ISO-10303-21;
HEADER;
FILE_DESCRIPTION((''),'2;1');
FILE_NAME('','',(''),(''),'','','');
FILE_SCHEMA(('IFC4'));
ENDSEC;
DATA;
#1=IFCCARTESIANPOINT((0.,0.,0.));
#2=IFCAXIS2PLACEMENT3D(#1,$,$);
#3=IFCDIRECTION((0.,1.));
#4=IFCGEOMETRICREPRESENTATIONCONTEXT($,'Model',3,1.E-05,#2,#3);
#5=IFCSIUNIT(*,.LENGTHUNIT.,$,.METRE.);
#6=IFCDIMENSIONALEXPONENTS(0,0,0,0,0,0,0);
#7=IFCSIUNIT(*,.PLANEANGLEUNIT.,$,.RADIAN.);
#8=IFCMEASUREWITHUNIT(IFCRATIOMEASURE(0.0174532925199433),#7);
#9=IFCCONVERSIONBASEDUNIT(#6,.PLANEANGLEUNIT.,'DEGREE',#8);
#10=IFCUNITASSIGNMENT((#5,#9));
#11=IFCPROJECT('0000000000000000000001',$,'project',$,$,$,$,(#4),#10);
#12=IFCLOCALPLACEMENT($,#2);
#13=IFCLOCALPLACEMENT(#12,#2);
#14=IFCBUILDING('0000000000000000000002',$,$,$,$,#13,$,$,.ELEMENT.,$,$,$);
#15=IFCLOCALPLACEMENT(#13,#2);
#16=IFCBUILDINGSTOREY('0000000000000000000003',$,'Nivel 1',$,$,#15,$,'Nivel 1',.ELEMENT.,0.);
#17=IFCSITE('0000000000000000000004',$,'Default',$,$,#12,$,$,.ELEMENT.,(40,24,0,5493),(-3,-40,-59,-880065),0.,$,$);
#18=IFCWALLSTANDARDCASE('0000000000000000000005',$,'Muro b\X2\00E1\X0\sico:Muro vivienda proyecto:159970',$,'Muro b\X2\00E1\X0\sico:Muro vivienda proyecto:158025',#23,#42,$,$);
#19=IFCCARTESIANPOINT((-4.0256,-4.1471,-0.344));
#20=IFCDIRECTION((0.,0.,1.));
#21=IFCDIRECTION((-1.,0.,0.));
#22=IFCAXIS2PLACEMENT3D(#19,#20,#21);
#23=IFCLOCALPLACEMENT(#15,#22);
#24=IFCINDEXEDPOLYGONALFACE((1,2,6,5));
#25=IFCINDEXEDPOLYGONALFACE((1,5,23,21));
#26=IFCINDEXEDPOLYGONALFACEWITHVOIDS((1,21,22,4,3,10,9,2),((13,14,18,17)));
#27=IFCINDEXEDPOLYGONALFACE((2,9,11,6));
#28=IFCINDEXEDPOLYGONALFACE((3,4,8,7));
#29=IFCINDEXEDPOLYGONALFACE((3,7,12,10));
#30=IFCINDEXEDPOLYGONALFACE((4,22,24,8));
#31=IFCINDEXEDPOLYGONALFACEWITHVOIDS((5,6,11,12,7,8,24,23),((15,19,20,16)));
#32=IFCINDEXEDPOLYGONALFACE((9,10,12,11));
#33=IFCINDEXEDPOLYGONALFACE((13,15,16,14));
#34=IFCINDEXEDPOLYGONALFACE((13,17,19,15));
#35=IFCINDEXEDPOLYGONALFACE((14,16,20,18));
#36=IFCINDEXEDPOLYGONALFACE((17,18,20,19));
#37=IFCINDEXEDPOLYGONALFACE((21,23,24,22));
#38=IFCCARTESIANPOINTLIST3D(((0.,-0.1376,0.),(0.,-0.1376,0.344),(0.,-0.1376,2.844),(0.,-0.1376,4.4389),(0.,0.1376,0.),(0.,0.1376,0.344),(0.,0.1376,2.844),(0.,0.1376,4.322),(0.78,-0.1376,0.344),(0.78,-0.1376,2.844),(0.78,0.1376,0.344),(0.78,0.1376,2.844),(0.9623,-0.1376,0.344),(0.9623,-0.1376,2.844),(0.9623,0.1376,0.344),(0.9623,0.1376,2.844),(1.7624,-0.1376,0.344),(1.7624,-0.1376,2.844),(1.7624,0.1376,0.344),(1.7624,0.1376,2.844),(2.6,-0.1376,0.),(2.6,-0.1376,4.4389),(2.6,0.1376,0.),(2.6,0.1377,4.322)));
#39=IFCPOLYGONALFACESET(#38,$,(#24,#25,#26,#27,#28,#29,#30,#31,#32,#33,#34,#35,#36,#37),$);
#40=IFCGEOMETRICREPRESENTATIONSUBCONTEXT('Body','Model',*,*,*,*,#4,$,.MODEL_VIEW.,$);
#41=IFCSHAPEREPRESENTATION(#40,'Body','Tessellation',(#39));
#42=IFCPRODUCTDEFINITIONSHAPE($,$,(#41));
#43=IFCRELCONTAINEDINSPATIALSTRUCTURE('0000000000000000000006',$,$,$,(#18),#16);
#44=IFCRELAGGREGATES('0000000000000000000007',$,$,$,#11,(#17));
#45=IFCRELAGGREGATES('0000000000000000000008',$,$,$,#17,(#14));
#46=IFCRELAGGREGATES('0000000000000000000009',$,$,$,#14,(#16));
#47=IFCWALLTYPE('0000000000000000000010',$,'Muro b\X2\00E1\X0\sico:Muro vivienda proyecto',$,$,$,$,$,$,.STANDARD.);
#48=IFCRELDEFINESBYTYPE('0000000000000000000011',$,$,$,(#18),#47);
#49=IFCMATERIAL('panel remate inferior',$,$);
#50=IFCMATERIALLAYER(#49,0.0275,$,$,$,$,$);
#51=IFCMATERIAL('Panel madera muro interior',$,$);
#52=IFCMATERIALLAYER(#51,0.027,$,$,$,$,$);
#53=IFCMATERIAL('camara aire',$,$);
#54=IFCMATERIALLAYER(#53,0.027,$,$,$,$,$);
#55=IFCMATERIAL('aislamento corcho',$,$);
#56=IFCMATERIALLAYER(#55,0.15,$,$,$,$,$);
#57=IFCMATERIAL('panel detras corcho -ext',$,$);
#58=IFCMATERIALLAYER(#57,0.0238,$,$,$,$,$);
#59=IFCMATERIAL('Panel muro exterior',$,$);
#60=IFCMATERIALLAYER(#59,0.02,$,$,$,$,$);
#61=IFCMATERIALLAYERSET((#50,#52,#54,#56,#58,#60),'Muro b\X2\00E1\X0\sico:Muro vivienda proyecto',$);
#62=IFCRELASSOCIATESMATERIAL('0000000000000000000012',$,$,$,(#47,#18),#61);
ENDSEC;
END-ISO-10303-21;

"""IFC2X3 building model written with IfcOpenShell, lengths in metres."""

from ifc_helpers import new_model, entity, si_unit, converted_unit, direction, frame, frame_2d, origin, origin_2d_with_axis, place, context, subcontext, project, spatial, polyline, rectangle, extrude, clip, bounded_halfspace, material, layer, layer_set, layer_usage, type_object, element, save


model = new_model("IFC2X3")

# Units and contexts
model_context = context("Model", 3, precision=1e-05, world=origin(), true_north=direction((0.0, 1.0)))
body_context = subcontext(model_context, "Body", "Model", "MODEL_VIEW")
ifc_project = project(units=[si_unit("LENGTHUNIT", "METRE"), converted_unit("PLANEANGLEUNIT", "DEGREE", entity("IfcRatioMeasure", 0.0174532925199433), si_unit("PLANEANGLEUNIT", "RADIAN"), dimensions=[0, 0, 0, 0, 0, 0, 0])], contexts=[model_context])

# Site, building, storey
site_placement = place(None, origin())
site = spatial("IfcSite", under=ifc_project, at=site_placement, Name="Default", CompositionType="ELEMENT", RefLatitude=(40, 24, 0, 5493), RefLongitude=(-3, -40, -59, -880065), RefElevation=0.0)
building_placement = place(site_placement, origin())
building = spatial("IfcBuilding", under=site, at=building_placement, CompositionType="ELEMENT")
storey_placement = place(building_placement, origin())
storey = spatial("IfcBuildingStorey", under=building, at=storey_placement, Name="Nivel 1", LongName="Nivel 1", CompositionType="ELEMENT", Elevation=0.0)

# Shared definitions
ifc_material_1 = material(Name="aislamento corcho")
ifc_material_2 = material(Name="camara aire")
ifc_material_3 = material(Name="panel remate inferior")

# Shared definitions
ifc_layer_1 = layer(ifc_material_3, 0.0275)
ifc_material_4 = material(Name="Panel madera muro interior")
ifc_layer_2 = layer(ifc_material_4, 0.027)
ifc_layer_3 = layer(ifc_material_2, 0.027)
ifc_layer_4 = layer(ifc_material_1, 0.15)
ifc_material_5 = material(Name="panel detras corcho -ext")
ifc_layer_5 = layer(ifc_material_5, 0.0238)
ifc_material_6 = material(Name="Panel muro exterior")
ifc_layer_6 = layer(ifc_material_6, 0.02)
ifc_layer_set_1 = layer_set([ifc_layer_1, ifc_layer_2, ifc_layer_3, ifc_layer_4, ifc_layer_5, ifc_layer_6], Name="Muro básico:Muro vivienda proyecto")
wall_type = type_object("IfcWallType", Name="Muro básico:Muro vivienda proyecto", PredefinedType="STANDARD", material=ifc_layer_set_1)

# Wall, openings
ifc_layer_usage_1 = layer_usage(ifc_layer_set_1, "AXIS2", "NEGATIVE", 0.1376)
wall_1_placement = place(storey_placement, frame((-4.0256, -4.1471, -0.344), z_axis=(0.0, 0.0, 1.0), x_axis=(-1.0, 0.0, 0.0)))
wall_1 = element("IfcWallStandardCase", 1, at=wall_1_placement, inside=storey, type_object=wall_type, material=ifc_layer_usage_1, Name="Muro básico:Muro vivienda proyecto:159970", ObjectType="Muro básico:Muro vivienda proyecto:158025", context=body_context, shape_type="Clipping", body=[
    clip(extrude(rectangle(XDim=2.6, YDim=0.2753, at=frame_2d((1.3, 0.0), x_axis=(-1.0, 0.0))), origin(), (0.0, 0.0, 1.0), 4.4389), bounded_halfspace(frame((0.0, -0.1376, 4.4389), z_axis=(0.0, 0.390731, 0.920505), x_axis=(-1.0, 0.0, 0.0)), False, frame((0.0, -0.1376, 4.4389)), polyline([(0.0, 0.0), (2.6, 0.0), (2.6, 0.2753), (0.0, 0.2753), (0.0, 0.0)]))),
])
opening_1_placement = place(wall_1_placement, origin())
element("IfcOpeningElement", 2, at=opening_1_placement, cuts=wall_1, ObjectType="Opening", context=body_context, shape_type="SweptSolid", body=[
    extrude(rectangle(XDim=2.5, YDim=0.8, at=origin_2d_with_axis()), frame((0.38, -0.29, 1.594), z_axis=(0.0, 1.0, 0.0), x_axis=(0.0, 0.0, 1.0)), (0.0, 0.0, 1.0), 0.5801),
])
opening_2_placement = place(wall_1_placement, origin())
element("IfcOpeningElement", 3, at=opening_2_placement, cuts=wall_1, ObjectType="Opening", context=body_context, shape_type="SweptSolid", body=[
    extrude(rectangle(XDim=2.5, YDim=0.8, at=origin_2d_with_axis()), frame((1.3623, -0.29, 1.594), z_axis=(0.0, 1.0, 0.0), x_axis=(0.0, 0.0, 1.0)), (0.0, 0.0, 1.0), 0.5801),
])

save(model, "model.ifc")
